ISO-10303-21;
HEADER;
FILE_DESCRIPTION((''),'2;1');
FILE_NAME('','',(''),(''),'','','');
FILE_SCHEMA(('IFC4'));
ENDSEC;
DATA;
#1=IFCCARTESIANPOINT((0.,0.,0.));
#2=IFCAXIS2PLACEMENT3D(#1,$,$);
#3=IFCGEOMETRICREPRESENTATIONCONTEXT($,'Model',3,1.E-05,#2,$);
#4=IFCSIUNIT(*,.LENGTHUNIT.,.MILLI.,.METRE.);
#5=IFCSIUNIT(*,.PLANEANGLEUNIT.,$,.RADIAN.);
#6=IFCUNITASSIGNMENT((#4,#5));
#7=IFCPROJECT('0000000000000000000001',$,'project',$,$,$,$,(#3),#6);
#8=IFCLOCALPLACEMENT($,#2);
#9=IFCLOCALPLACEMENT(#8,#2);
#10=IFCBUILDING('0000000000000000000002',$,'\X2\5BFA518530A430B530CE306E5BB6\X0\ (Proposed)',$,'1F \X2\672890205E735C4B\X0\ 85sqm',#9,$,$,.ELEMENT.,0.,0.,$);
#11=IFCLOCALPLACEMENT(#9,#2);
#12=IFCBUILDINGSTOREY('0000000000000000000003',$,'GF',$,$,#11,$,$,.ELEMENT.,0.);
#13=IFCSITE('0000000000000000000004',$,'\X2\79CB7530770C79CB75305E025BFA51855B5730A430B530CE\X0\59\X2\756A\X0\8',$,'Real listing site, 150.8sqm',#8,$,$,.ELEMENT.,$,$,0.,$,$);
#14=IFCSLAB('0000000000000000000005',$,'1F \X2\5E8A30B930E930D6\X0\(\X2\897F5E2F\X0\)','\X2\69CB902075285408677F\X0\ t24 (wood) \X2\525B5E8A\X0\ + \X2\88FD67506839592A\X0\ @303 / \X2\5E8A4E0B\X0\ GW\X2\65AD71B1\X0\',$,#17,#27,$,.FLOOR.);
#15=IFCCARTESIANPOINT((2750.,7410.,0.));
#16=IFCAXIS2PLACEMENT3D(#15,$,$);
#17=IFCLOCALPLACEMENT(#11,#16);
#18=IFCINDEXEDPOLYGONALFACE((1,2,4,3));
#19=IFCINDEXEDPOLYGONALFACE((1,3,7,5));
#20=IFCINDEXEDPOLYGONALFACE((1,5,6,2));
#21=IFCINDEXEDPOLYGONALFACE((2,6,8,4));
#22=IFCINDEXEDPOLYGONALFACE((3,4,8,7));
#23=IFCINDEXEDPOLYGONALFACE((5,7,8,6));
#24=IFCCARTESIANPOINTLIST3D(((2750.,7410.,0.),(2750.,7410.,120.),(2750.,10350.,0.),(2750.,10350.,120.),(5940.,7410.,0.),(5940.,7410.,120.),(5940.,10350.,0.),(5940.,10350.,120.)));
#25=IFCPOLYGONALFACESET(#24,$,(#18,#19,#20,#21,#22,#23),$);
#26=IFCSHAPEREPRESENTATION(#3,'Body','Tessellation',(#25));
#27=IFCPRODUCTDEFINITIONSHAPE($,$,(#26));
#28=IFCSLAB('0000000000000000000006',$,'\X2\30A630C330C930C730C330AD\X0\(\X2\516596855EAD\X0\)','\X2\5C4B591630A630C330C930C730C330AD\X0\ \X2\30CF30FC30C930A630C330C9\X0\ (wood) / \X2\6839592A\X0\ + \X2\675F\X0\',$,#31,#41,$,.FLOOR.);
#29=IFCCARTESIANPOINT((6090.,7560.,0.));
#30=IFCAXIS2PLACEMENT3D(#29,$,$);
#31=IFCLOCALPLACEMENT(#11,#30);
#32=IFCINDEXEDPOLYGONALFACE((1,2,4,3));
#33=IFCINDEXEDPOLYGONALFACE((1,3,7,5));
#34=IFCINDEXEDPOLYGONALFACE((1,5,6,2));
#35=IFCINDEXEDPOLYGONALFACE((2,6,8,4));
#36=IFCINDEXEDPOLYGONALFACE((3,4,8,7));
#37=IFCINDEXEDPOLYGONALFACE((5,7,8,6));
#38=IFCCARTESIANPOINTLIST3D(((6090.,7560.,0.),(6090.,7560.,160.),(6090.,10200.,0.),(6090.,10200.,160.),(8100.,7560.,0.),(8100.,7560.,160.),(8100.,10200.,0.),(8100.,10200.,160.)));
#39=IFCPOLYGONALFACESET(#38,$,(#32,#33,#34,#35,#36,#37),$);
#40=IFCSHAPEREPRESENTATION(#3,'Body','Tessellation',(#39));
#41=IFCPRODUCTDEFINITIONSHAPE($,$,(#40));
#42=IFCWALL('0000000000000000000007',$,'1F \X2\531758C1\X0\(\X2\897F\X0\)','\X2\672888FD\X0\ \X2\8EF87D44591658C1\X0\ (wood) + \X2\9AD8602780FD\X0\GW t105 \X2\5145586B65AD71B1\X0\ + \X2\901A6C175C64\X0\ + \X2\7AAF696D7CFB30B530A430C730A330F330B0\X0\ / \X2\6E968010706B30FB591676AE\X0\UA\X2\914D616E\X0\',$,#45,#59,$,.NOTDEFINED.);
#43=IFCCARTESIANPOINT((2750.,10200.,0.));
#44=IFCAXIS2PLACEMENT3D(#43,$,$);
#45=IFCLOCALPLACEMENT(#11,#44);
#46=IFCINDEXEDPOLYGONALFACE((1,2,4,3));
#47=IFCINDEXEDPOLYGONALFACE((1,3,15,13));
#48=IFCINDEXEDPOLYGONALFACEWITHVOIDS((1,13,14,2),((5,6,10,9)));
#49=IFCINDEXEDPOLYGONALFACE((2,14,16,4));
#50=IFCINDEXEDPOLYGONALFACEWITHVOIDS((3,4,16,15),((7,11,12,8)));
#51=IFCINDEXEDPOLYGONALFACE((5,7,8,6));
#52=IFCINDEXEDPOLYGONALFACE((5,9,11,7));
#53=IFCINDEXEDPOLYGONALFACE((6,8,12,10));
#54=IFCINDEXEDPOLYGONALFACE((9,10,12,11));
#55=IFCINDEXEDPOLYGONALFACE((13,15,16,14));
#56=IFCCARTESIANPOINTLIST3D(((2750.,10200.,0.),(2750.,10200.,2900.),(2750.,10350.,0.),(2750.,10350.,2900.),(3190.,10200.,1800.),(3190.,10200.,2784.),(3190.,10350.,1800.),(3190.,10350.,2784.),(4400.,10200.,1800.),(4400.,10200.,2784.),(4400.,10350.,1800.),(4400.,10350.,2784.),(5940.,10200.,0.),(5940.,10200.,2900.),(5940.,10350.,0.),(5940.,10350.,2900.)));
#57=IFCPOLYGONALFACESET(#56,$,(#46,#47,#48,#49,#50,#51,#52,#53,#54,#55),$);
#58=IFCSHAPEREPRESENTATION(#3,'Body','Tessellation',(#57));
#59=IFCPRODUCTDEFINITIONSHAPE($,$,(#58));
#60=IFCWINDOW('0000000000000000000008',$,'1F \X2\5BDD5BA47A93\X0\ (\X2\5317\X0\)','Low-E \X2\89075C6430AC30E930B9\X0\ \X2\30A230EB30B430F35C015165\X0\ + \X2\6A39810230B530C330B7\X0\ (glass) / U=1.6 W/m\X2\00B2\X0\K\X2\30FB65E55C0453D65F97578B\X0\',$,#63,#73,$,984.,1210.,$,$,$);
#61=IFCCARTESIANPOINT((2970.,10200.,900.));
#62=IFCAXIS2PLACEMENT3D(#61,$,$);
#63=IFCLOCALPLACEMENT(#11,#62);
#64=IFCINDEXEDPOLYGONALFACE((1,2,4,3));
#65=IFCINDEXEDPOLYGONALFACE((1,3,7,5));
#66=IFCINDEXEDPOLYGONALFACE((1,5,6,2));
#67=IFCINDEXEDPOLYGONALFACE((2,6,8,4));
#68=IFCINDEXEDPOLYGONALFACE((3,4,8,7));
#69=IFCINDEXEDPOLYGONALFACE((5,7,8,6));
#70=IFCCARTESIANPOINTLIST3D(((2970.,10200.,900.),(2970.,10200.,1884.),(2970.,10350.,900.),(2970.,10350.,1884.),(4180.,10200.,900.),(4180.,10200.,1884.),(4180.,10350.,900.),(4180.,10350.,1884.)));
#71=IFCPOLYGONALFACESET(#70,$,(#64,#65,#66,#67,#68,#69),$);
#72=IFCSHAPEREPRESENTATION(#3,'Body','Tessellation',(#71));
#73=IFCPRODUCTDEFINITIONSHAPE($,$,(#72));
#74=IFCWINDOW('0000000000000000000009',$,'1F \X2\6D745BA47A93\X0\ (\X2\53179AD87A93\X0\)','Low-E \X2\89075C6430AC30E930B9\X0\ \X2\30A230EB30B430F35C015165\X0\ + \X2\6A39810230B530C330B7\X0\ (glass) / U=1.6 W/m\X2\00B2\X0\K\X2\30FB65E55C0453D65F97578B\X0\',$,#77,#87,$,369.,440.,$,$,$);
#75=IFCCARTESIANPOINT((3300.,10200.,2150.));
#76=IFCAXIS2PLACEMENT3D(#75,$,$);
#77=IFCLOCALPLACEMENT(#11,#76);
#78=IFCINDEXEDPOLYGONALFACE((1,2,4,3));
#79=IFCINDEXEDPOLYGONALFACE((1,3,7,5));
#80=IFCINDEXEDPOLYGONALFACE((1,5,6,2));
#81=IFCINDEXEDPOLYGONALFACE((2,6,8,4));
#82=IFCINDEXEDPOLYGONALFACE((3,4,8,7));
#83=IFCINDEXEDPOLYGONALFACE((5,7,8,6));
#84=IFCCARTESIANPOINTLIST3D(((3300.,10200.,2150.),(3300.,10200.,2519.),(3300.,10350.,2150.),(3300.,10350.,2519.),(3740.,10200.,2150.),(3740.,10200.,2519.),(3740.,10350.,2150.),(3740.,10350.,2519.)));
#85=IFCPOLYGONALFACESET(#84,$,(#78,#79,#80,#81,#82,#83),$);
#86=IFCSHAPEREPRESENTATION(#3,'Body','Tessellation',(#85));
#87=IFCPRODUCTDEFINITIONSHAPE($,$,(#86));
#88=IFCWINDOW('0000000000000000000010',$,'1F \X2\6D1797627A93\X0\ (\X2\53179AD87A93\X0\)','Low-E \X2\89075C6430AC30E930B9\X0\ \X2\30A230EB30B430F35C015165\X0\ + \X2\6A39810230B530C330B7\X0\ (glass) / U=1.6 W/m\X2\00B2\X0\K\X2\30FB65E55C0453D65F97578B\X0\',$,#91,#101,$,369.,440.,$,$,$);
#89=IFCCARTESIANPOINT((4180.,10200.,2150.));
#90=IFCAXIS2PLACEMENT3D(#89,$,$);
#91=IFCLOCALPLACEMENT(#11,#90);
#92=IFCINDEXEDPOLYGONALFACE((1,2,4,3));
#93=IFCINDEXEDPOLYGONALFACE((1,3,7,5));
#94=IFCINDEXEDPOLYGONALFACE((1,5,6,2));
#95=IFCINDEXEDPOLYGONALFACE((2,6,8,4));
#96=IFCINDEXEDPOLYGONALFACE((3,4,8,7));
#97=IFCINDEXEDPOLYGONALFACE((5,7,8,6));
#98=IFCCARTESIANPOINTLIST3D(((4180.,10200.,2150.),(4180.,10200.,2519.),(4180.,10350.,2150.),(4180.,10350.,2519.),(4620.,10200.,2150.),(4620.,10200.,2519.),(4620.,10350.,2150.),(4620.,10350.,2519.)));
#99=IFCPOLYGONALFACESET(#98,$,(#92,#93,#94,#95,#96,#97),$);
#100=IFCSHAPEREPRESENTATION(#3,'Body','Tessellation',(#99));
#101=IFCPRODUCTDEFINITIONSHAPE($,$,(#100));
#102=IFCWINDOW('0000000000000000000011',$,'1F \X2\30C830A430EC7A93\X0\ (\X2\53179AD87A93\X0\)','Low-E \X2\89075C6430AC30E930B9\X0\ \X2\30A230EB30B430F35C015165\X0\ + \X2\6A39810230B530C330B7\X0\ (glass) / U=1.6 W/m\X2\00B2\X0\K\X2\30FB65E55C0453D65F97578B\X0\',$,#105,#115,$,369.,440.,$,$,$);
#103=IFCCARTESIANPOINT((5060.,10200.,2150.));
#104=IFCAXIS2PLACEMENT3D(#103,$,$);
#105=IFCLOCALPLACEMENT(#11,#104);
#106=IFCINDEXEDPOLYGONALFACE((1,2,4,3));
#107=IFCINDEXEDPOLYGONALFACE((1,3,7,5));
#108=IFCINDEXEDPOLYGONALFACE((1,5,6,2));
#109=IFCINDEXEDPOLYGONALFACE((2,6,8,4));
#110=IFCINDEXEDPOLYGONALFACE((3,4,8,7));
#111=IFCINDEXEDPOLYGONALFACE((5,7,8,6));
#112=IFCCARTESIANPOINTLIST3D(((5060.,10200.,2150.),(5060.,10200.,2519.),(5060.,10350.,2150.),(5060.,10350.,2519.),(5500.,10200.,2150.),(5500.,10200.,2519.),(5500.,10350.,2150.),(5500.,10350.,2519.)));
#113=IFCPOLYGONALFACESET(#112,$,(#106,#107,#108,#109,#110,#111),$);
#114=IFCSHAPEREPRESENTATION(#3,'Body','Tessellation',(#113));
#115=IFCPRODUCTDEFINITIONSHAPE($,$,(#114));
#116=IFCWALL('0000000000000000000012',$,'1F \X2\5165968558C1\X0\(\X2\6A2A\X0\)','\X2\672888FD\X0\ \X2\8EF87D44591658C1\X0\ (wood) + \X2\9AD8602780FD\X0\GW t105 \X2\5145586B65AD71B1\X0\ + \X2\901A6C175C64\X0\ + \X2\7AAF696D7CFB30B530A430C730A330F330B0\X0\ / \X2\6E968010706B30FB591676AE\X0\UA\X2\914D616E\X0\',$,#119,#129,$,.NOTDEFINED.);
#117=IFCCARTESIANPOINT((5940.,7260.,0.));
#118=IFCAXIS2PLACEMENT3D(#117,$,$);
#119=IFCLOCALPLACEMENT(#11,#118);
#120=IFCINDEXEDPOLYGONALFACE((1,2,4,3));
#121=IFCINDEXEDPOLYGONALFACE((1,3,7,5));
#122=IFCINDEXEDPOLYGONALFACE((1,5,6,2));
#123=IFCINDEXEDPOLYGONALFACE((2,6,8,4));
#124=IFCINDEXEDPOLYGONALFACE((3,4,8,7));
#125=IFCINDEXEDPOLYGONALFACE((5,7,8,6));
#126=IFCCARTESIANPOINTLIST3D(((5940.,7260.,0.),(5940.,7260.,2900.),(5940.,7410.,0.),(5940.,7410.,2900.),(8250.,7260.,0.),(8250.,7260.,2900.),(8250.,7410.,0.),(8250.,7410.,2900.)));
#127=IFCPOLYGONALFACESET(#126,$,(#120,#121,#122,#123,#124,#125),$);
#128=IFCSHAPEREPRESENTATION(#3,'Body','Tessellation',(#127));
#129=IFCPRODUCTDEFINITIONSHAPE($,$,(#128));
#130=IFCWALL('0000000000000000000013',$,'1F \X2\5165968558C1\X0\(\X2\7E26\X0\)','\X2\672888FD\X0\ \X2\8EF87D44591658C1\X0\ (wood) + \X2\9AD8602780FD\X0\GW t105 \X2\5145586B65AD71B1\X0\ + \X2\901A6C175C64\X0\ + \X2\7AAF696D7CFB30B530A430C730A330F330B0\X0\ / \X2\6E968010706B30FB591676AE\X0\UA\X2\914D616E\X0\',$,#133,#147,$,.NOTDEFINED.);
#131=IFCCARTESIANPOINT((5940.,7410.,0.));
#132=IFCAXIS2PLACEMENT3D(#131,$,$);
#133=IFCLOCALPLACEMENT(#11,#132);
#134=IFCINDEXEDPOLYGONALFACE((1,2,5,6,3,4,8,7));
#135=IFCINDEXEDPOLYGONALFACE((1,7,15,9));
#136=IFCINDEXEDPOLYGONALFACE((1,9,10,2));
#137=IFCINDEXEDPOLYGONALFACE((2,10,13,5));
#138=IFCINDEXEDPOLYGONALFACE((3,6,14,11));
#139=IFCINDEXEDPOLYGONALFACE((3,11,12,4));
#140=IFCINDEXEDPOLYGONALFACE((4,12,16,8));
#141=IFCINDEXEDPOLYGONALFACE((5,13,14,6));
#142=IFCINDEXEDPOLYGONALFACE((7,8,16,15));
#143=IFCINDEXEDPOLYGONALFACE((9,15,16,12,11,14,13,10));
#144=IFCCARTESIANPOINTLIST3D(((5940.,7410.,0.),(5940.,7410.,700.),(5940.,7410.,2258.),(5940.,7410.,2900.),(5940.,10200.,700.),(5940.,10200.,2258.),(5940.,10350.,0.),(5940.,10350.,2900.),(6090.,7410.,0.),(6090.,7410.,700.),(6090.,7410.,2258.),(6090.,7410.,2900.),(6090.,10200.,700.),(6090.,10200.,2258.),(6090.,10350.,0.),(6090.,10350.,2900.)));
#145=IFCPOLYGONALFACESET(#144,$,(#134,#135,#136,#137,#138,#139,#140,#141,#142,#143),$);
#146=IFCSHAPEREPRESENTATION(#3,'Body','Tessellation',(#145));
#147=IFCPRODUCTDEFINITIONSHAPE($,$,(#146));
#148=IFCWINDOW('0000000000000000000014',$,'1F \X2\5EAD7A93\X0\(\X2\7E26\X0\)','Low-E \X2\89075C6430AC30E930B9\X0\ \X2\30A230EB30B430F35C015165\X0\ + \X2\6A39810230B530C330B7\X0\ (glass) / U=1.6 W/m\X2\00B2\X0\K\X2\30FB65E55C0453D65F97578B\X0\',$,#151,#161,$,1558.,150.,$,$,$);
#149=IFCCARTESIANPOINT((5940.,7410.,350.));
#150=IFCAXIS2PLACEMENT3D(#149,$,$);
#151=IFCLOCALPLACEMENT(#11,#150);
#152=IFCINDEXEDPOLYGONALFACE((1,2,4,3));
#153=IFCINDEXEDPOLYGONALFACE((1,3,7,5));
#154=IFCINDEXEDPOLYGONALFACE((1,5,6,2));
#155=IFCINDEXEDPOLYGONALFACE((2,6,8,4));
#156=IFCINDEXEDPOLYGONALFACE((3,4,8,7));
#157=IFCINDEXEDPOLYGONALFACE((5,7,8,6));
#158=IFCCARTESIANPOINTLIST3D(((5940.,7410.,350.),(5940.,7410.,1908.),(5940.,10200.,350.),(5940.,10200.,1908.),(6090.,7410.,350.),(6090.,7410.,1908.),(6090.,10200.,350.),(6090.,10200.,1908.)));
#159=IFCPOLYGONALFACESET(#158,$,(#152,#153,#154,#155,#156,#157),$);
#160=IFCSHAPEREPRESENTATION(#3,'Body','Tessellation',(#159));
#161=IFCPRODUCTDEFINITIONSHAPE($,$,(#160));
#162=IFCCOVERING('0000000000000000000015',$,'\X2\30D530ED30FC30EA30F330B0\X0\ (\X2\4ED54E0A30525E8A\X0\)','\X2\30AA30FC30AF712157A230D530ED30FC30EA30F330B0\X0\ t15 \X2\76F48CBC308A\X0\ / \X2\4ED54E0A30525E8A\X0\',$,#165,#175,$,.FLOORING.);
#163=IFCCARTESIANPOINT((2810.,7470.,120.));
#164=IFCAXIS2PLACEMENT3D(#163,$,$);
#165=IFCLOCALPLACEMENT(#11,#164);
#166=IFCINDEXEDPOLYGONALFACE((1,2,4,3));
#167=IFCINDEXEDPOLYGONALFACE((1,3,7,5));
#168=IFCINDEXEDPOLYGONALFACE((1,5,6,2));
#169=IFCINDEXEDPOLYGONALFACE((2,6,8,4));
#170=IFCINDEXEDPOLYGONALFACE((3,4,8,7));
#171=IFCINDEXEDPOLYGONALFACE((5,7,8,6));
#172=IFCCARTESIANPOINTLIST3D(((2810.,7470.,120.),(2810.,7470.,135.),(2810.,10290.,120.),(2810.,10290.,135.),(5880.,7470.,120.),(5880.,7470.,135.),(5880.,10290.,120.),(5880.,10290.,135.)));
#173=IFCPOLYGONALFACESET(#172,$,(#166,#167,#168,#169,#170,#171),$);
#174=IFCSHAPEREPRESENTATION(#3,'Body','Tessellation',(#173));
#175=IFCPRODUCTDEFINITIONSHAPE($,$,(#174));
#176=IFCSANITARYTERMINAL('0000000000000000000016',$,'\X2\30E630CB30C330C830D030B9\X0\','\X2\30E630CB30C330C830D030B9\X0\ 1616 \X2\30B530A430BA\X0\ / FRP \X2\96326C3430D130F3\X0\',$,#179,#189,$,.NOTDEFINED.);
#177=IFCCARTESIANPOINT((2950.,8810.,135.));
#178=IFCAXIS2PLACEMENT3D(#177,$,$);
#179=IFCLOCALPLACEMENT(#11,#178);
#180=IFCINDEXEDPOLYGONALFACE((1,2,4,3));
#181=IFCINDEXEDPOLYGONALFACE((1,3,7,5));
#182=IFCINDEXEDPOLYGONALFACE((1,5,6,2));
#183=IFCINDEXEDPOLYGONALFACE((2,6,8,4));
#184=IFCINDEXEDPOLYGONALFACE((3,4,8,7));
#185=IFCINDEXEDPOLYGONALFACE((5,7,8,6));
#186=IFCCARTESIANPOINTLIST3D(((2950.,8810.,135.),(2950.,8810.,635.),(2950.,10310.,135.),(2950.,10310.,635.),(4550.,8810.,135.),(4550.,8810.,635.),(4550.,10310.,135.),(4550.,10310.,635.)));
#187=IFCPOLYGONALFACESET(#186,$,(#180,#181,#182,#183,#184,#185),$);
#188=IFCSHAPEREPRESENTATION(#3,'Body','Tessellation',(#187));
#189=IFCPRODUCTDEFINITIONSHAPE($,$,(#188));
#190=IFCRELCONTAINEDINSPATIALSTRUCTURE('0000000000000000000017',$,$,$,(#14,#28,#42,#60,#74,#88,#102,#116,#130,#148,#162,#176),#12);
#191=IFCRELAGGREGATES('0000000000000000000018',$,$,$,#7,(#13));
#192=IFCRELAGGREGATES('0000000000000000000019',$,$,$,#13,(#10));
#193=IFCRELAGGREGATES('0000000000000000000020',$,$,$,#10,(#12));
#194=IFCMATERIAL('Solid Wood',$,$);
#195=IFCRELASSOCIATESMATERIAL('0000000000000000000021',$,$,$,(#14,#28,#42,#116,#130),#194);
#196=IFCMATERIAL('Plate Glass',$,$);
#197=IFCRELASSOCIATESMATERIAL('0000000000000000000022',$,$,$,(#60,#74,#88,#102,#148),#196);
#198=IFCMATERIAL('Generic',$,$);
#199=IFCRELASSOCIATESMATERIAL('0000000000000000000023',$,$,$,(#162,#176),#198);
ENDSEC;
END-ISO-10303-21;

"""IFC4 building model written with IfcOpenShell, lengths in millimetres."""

from ifc_helpers import new_model, si_unit, frame, frame_2d, origin, place, context, project, spatial, rectangle, extrude, material, element, fill, save


model = new_model("IFC4")

# Units and contexts
model_context = context("Model", 3, precision=1e-05, world=origin())
ifc_project = project(units=[si_unit("LENGTHUNIT", "METRE", prefix="MILLI"), si_unit("PLANEANGLEUNIT", "RADIAN")], contexts=[model_context])

# Site, building, storey
site_placement = place(None, origin())
site = spatial("IfcSite", under=ifc_project, at=site_placement, Name="秋田県秋田市寺内字イサノ59番8", ObjectType="Real listing site, 150.8sqm", CompositionType="ELEMENT", RefElevation=0.0)
building_placement = place(site_placement, origin())
building = spatial("IfcBuilding", under=site, at=building_placement, Name="寺内イサノの家 (Proposed)", ObjectType="1F 木造平屋 85sqm", CompositionType="ELEMENT", ElevationOfRefHeight=0.0, ElevationOfTerrain=0.0)
storey_placement = place(building_placement, origin())
storey = spatial("IfcBuildingStorey", under=building, at=storey_placement, Name="GF", CompositionType="ELEMENT", Elevation=0.0)

# Slabs
ifc_material_1 = material(Name="Solid Wood")
slab_1_placement = place(storey_placement, frame((2750.0, 7410.0, 0.0)))
element("IfcSlab", 1, at=slab_1_placement, inside=storey, material=ifc_material_1, Name="1F 床スラブ(西帯)", Description="構造用合板 t24 (wood) 剛床 + 製材根太 @303 / 床下 GW断熱", PredefinedType="FLOOR", context=model_context, shape_type="SweptSolid", body=[
    extrude(rectangle(XDim=3190.0, YDim=2940.0, at=frame_2d((1595.0, 1470.0))), frame((2750.0, 7410.0, 0.0)), (0.0, 0.0, 1.0), 120.0),
])
slab_2_placement = place(storey_placement, frame((6090.0, 7560.0, 0.0)))
element("IfcSlab", 2, at=slab_2_placement, inside=storey, material=ifc_material_1, Name="ウッドデッキ(入隅庭)", Description="屋外ウッドデッキ ハードウッド (wood) / 根太 + 束", PredefinedType="FLOOR", context=model_context, shape_type="SweptSolid", body=[
    extrude(rectangle(XDim=2010.0, YDim=2640.0, at=frame_2d((1005.0, 1320.0))), frame((6090.0, 7560.0, 0.0)), (0.0, 0.0, 1.0), 160.0),
])

# Wall, openings, windows
wall_1_placement = place(storey_placement, frame((2750.0, 10200.0, 0.0)))
wall_1 = element("IfcWall", 3, at=wall_1_placement, inside=storey, material=ifc_material_1, Name="1F 北壁(西)", Description="木製 軸組外壁 (wood) + 高性能GW t105 充填断熱 + 通気層 + 窯業系サイディング / 準耐火・外皮UA配慮", PredefinedType="NOTDEFINED", context=model_context, shape_type="SweptSolid", body=[
    extrude(rectangle(XDim=3190.0, YDim=150.0, at=frame_2d((1595.0, 75.0))), frame((2750.0, 10200.0, 0.0)), (0.0, 0.0, 1.0), 2900.0),
])
opening_1_placement = place(storey_placement, frame((2970.0, 10200.0, 900.0)))
opening_1 = element("IfcOpeningElement", 4, at=opening_1_placement, cuts=wall_1, PredefinedType="NOTDEFINED", context=model_context, shape_type="SweptSolid", body=[
    extrude(rectangle(XDim=1210.0, YDim=150.0, at=frame_2d((605.0, 75.0))), frame((2970.0, 10200.0, 900.0)), (0.0, 0.0, 1.0), 984.0),
])
opening_2_placement = place(storey_placement, frame((3300.0, 10200.0, 2150.0)))
opening_2 = element("IfcOpeningElement", 5, at=opening_2_placement, cuts=wall_1, PredefinedType="NOTDEFINED", context=model_context, shape_type="SweptSolid", body=[
    extrude(rectangle(XDim=440.0, YDim=150.0, at=frame_2d((220.0, 75.0))), frame((3300.0, 10200.0, 2150.0)), (0.0, 0.0, 1.0), 369.0),
])
opening_3_placement = place(storey_placement, frame((4180.0, 10200.0, 2150.0)))
opening_3 = element("IfcOpeningElement", 6, at=opening_3_placement, cuts=wall_1, PredefinedType="NOTDEFINED", context=model_context, shape_type="SweptSolid", body=[
    extrude(rectangle(XDim=440.0, YDim=150.0, at=frame_2d((220.0, 75.0))), frame((4180.0, 10200.0, 2150.0)), (0.0, 0.0, 1.0), 369.0),
])
opening_4_placement = place(storey_placement, frame((5060.0, 10200.0, 2150.0)))
opening_4 = element("IfcOpeningElement", 7, at=opening_4_placement, cuts=wall_1, PredefinedType="NOTDEFINED", context=model_context, shape_type="SweptSolid", body=[
    extrude(rectangle(XDim=440.0, YDim=150.0, at=frame_2d((220.0, 75.0))), frame((5060.0, 10200.0, 2150.0)), (0.0, 0.0, 1.0), 369.0),
])
ifc_material_2 = material(Name="Plate Glass")
window_1_placement = place(storey_placement, frame((2970.0, 10200.0, 900.0)))
window_1 = element("IfcWindow", 8, at=window_1_placement, inside=storey, material=ifc_material_2, Name="1F 寝室窓 (北)", Description="Low-E 複層ガラス アルゴン封入 + 樹脂サッシ (glass) / U=1.6 W/m²K・日射取得型", OverallHeight=984.0, OverallWidth=1210.0, context=model_context, shape_type="SweptSolid", body=[
    extrude(rectangle(XDim=1210.0, YDim=150.0, at=frame_2d((605.0, 75.0))), frame((2970.0, 10200.0, 900.0)), (0.0, 0.0, 1.0), 984.0),
])
fill(opening_1, window_1)
window_2_placement = place(storey_placement, frame((3300.0, 10200.0, 2150.0)))
window_2 = element("IfcWindow", 9, at=window_2_placement, inside=storey, material=ifc_material_2, Name="1F 浴室窓 (北高窓)", Description="Low-E 複層ガラス アルゴン封入 + 樹脂サッシ (glass) / U=1.6 W/m²K・日射取得型", OverallHeight=369.0, OverallWidth=440.0, context=model_context, shape_type="SweptSolid", body=[
    extrude(rectangle(XDim=440.0, YDim=150.0, at=frame_2d((220.0, 75.0))), frame((3300.0, 10200.0, 2150.0)), (0.0, 0.0, 1.0), 369.0),
])
fill(opening_2, window_2)
window_3_placement = place(storey_placement, frame((4180.0, 10200.0, 2150.0)))
window_3 = element("IfcWindow", 10, at=window_3_placement, inside=storey, material=ifc_material_2, Name="1F 洗面窓 (北高窓)", Description="Low-E 複層ガラス アルゴン封入 + 樹脂サッシ (glass) / U=1.6 W/m²K・日射取得型", OverallHeight=369.0, OverallWidth=440.0, context=model_context, shape_type="SweptSolid", body=[
    extrude(rectangle(XDim=440.0, YDim=150.0, at=frame_2d((220.0, 75.0))), frame((4180.0, 10200.0, 2150.0)), (0.0, 0.0, 1.0), 369.0),
])
fill(opening_3, window_3)
window_4_placement = place(storey_placement, frame((5060.0, 10200.0, 2150.0)))
window_4 = element("IfcWindow", 11, at=window_4_placement, inside=storey, material=ifc_material_2, Name="1F トイレ窓 (北高窓)", Description="Low-E 複層ガラス アルゴン封入 + 樹脂サッシ (glass) / U=1.6 W/m²K・日射取得型", OverallHeight=369.0, OverallWidth=440.0, context=model_context, shape_type="SweptSolid", body=[
    extrude(rectangle(XDim=440.0, YDim=150.0, at=frame_2d((220.0, 75.0))), frame((5060.0, 10200.0, 2150.0)), (0.0, 0.0, 1.0), 369.0),
])
fill(opening_4, window_4)

# Wall
wall_2_placement = place(storey_placement, frame((5940.0, 7260.0, 0.0)))
element("IfcWall", 12, at=wall_2_placement, inside=storey, material=ifc_material_1, Name="1F 入隅壁(横)", Description="木製 軸組外壁 (wood) + 高性能GW t105 充填断熱 + 通気層 + 窯業系サイディング / 準耐火・外皮UA配慮", PredefinedType="NOTDEFINED", context=model_context, shape_type="SweptSolid", body=[
    extrude(rectangle(XDim=2310.0, YDim=150.0, at=frame_2d((1155.0, 75.0))), frame((5940.0, 7260.0, 0.0)), (0.0, 0.0, 1.0), 2900.0),
])

# Wall, opening, window
wall_3_placement = place(storey_placement, frame((5940.0, 7410.0, 0.0)))
wall_3 = element("IfcWall", 13, at=wall_3_placement, inside=storey, material=ifc_material_1, Name="1F 入隅壁(縦)", Description="木製 軸組外壁 (wood) + 高性能GW t105 充填断熱 + 通気層 + 窯業系サイディング / 準耐火・外皮UA配慮", PredefinedType="NOTDEFINED", context=model_context, shape_type="SweptSolid", body=[
    extrude(rectangle(XDim=150.0, YDim=2940.0, at=frame_2d((75.0, 1470.0))), frame((5940.0, 7410.0, 0.0)), (0.0, 0.0, 1.0), 2900.0),
])
opening_5_placement = place(storey_placement, frame((5940.0, 7410.0, 350.0)))
opening_5 = element("IfcOpeningElement", 14, at=opening_5_placement, cuts=wall_3, PredefinedType="NOTDEFINED", context=model_context, shape_type="SweptSolid", body=[
    extrude(rectangle(XDim=150.0, YDim=2790.0, at=frame_2d((75.0, 1395.0))), frame((5940.0, 7410.0, 350.0)), (0.0, 0.0, 1.0), 1558.0),
])
window_5_placement = place(storey_placement, frame((5940.0, 7410.0, 350.0)))
window_5 = element("IfcWindow", 15, at=window_5_placement, inside=storey, material=ifc_material_2, Name="1F 庭窓(縦)", Description="Low-E 複層ガラス アルゴン封入 + 樹脂サッシ (glass) / U=1.6 W/m²K・日射取得型", OverallHeight=1558.0, OverallWidth=150.0, context=model_context, shape_type="SweptSolid", body=[
    extrude(rectangle(XDim=150.0, YDim=2790.0, at=frame_2d((75.0, 1395.0))), frame((5940.0, 7410.0, 350.0)), (0.0, 0.0, 1.0), 1558.0),
])
fill(opening_5, window_5)

# Covering
ifc_material_3 = material(Name="Generic")
covering_placement = place(storey_placement, frame((2810.0, 7470.0, 120.0)))
element("IfcCovering", 16, at=covering_placement, inside=storey, material=ifc_material_3, Name="フローリング (仕上げ床)", Description="オーク無垢フローリング t15 直貼り / 仕上げ床", PredefinedType="FLOORING", context=model_context, shape_type="SweptSolid", body=[
    extrude(rectangle(XDim=3070.0, YDim=2820.0, at=frame_2d((1535.0, 1410.0))), frame((2810.0, 7470.0, 120.0)), (0.0, 0.0, 1.0), 15.0),
])

# Sanitary terminal
sanitary_terminal_1_placement = place(storey_placement, frame((2950.0, 8810.0, 135.0)))
element("IfcSanitaryTerminal", 17, at=sanitary_terminal_1_placement, inside=storey, material=ifc_material_3, Name="ユニットバス", Description="ユニットバス 1616 サイズ / FRP 防水パン", PredefinedType="NOTDEFINED", context=model_context, shape_type="SweptSolid", body=[
    extrude(rectangle(XDim=1600.0, YDim=1500.0, at=frame_2d((800.0, 750.0))), frame((2950.0, 8810.0, 135.0)), (0.0, 0.0, 1.0), 500.0),
])

save(model, "model.ifc")
